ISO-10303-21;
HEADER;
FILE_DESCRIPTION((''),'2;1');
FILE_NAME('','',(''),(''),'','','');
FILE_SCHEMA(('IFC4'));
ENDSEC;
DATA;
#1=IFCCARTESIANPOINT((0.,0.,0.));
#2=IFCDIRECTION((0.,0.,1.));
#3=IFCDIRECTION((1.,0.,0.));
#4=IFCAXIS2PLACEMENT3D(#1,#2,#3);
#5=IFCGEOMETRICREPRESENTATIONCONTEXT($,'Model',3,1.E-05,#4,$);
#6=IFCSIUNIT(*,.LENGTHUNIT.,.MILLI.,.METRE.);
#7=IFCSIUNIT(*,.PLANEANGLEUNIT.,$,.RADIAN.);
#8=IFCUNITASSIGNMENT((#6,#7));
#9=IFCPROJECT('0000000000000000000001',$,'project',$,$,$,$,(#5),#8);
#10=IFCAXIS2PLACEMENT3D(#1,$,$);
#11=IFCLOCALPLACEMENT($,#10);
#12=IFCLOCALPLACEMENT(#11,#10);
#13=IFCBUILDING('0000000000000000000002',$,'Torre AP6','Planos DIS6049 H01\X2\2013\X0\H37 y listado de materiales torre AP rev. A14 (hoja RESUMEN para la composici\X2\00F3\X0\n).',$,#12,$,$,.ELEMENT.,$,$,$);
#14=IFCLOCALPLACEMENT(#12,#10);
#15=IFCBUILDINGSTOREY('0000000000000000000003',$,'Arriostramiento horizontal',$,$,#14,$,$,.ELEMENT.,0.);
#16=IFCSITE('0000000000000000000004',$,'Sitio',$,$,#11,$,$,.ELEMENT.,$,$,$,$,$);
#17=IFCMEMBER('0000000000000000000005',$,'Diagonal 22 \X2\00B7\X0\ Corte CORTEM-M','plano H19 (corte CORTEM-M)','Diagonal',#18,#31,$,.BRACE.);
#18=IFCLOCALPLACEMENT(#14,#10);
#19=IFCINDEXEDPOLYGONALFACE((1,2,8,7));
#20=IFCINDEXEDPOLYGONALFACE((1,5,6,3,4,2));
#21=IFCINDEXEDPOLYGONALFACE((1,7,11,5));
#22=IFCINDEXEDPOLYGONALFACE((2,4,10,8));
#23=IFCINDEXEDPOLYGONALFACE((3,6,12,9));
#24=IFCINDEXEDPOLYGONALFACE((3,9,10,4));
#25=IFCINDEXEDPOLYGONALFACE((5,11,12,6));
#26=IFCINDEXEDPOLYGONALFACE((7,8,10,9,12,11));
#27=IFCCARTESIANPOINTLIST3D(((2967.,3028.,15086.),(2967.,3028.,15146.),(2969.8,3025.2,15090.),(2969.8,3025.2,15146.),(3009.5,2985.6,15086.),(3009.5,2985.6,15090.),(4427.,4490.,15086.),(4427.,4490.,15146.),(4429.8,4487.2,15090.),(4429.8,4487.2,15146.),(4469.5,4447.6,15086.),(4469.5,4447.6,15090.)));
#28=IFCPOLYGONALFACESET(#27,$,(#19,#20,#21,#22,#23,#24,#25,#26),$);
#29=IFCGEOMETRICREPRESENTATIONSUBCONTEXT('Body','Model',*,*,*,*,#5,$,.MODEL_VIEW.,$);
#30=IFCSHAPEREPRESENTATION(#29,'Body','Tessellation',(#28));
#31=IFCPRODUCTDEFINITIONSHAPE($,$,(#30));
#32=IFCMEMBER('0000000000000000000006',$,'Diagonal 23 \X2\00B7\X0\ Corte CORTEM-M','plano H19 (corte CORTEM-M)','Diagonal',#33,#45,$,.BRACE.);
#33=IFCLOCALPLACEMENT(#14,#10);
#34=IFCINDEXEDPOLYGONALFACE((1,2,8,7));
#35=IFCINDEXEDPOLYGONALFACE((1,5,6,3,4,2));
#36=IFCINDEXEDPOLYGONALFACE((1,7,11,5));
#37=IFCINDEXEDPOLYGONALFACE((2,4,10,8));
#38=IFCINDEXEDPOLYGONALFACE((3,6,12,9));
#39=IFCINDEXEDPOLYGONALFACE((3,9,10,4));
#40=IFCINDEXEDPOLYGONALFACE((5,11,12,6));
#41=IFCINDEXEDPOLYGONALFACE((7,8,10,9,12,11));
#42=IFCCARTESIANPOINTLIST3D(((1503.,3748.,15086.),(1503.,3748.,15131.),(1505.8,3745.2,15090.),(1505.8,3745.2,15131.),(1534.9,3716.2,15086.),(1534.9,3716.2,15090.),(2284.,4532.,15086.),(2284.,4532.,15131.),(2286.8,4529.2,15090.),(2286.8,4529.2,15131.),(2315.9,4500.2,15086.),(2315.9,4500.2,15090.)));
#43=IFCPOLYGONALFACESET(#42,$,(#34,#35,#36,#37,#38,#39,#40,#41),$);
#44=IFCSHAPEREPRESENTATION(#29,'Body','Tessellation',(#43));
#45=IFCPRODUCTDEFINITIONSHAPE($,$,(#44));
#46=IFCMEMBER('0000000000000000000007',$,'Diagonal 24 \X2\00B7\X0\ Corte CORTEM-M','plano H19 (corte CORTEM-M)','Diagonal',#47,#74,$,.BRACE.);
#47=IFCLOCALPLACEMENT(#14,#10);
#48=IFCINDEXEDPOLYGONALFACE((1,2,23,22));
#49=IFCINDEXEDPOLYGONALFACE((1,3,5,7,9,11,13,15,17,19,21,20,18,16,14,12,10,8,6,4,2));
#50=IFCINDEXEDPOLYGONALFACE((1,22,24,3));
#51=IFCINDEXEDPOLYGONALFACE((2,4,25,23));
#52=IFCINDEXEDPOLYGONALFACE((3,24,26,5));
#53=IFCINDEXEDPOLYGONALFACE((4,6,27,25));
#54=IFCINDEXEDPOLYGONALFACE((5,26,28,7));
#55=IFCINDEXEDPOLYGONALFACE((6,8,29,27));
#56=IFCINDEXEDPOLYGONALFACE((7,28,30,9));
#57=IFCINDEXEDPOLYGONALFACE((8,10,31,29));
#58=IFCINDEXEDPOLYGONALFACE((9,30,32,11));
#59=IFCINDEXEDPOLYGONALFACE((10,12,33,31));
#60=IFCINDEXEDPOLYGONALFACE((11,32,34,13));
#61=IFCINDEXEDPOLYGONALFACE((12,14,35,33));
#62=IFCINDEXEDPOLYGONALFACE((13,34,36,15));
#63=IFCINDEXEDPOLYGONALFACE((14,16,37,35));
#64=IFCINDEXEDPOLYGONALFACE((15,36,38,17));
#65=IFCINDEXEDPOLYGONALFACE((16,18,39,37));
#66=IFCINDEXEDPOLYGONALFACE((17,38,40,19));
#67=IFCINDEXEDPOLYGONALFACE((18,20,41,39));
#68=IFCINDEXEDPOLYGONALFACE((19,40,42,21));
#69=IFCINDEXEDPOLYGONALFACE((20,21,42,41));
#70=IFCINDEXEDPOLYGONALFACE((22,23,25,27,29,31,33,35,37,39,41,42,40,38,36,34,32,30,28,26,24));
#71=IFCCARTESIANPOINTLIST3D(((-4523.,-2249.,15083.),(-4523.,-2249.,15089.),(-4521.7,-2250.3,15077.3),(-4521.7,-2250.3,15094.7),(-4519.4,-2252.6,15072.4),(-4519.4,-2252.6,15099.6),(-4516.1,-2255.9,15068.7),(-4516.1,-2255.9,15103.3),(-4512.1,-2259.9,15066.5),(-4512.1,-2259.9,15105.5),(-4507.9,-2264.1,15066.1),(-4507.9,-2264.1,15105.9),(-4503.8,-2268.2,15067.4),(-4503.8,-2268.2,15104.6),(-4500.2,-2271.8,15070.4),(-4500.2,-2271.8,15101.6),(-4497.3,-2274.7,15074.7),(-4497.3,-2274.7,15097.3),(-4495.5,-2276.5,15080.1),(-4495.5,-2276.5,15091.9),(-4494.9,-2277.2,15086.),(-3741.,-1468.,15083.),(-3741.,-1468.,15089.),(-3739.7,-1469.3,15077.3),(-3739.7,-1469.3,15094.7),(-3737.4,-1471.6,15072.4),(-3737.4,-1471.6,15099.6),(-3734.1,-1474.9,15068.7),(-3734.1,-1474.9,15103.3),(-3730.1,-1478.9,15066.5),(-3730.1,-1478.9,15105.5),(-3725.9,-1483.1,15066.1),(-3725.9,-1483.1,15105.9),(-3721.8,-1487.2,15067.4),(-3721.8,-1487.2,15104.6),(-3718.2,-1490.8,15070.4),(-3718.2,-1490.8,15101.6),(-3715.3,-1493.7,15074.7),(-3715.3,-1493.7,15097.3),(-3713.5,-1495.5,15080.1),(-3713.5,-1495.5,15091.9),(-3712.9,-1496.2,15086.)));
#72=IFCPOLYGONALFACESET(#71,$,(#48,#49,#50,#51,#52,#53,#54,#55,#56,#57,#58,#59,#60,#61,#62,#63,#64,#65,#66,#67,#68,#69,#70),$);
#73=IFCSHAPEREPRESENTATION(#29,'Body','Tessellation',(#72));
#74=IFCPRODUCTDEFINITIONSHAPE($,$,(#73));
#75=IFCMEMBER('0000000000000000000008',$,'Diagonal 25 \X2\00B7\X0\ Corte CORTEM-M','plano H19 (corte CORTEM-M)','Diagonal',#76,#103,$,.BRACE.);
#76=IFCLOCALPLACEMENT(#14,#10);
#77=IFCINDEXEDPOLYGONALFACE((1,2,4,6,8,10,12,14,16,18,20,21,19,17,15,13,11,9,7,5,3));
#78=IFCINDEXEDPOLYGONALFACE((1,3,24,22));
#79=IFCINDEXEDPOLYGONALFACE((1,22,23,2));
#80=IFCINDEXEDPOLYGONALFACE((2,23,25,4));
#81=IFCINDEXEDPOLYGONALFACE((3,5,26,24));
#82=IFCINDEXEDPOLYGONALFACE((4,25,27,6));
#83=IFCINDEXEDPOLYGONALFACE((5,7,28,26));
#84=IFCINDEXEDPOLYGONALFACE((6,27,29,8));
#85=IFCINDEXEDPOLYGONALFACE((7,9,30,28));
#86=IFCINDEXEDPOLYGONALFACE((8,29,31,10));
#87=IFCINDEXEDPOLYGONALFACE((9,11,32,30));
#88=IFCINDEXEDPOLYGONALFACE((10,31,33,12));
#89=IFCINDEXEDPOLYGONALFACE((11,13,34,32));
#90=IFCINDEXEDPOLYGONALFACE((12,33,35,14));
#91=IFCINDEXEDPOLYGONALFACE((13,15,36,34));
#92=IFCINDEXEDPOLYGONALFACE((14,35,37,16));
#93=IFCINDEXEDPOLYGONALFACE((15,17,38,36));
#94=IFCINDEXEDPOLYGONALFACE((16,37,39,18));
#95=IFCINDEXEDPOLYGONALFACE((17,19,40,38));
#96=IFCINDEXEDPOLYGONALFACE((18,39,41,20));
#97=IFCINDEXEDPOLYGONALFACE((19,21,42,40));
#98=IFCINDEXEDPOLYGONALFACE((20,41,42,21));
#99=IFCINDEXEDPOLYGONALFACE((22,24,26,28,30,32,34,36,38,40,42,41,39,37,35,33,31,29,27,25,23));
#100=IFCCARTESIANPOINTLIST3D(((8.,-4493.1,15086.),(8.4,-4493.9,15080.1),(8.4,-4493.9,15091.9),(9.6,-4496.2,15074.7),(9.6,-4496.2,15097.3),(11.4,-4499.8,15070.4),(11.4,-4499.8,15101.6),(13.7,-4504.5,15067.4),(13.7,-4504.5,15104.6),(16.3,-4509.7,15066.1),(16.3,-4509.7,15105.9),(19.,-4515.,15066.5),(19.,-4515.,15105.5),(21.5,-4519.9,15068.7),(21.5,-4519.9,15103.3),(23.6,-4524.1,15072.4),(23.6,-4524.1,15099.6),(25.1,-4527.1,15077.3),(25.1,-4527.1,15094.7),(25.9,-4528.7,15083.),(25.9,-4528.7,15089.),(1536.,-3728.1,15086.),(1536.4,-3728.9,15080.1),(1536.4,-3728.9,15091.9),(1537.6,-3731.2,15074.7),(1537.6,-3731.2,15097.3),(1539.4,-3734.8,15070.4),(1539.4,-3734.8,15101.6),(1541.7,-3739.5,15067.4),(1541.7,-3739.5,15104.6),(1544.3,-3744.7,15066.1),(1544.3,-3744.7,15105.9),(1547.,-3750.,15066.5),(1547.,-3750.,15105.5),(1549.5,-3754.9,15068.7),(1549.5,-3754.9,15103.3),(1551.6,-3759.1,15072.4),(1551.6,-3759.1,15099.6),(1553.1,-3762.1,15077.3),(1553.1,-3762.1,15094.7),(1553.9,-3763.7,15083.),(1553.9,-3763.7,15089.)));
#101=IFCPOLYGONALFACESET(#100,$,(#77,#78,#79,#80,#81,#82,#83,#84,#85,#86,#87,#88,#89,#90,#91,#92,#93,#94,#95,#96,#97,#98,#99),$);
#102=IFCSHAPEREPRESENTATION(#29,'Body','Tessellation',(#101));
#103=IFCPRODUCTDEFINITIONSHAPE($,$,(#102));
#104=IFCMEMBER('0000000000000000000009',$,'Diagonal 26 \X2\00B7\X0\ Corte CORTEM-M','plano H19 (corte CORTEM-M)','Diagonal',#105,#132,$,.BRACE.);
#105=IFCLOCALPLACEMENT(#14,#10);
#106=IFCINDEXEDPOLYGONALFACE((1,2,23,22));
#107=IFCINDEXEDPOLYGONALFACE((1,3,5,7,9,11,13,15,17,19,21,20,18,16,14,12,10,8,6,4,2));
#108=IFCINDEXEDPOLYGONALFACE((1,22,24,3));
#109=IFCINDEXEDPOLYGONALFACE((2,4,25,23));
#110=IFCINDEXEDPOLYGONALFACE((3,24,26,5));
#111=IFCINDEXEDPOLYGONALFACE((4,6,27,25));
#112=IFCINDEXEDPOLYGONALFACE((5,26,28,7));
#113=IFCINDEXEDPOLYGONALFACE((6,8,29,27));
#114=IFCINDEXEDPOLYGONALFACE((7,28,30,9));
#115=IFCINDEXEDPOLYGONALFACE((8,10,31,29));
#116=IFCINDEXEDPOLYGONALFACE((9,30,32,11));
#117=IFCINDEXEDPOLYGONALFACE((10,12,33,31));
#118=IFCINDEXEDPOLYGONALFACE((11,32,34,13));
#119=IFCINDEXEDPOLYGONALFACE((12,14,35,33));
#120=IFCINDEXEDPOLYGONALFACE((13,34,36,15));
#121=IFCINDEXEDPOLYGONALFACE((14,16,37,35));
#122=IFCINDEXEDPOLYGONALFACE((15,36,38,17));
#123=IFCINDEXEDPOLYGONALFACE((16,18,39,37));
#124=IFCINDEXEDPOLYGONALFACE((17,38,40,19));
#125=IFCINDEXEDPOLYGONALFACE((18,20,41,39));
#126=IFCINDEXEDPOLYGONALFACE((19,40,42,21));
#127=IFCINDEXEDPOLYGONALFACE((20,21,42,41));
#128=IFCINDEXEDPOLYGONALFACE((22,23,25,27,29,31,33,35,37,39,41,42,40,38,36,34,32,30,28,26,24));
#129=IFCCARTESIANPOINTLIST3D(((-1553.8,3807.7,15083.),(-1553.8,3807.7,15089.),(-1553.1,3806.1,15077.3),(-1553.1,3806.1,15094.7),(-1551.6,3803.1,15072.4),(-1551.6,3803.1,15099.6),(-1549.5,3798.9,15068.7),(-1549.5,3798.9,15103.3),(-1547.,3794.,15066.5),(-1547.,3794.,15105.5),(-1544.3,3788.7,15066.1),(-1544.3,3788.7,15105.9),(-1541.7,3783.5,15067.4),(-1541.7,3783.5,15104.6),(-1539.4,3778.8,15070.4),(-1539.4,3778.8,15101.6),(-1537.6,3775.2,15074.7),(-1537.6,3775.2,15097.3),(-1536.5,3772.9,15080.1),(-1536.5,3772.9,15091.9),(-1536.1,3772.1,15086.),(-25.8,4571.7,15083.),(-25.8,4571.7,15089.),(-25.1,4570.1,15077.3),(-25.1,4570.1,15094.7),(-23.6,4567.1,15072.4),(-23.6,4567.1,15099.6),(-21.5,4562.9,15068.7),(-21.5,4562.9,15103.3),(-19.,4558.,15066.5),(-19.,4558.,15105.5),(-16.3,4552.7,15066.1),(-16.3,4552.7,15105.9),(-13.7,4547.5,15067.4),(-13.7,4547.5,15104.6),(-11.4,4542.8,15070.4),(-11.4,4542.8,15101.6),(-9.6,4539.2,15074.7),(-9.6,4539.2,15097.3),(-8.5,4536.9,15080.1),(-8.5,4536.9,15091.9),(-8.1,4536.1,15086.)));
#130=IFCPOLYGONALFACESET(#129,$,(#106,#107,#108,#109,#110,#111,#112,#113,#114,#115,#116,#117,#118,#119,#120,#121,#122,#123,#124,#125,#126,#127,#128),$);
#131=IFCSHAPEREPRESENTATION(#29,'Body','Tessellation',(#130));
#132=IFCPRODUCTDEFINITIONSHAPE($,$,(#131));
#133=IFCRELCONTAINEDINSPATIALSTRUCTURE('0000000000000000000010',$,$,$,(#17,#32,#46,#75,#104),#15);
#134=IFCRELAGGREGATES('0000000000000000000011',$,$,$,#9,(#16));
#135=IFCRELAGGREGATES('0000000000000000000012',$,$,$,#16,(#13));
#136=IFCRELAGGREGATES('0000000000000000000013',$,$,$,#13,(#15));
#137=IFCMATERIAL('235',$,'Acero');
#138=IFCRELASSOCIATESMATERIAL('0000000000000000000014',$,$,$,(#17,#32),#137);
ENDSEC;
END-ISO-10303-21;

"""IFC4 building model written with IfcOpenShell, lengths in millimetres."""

from ifc_helpers import new_model, si_unit, frame, frame_2d, origin, origin_with_axes, place, context, subcontext, project, spatial, circle, l_section, extrude, material, element, save


model = new_model("IFC4")

# Units and contexts
model_context = context("Model", 3, precision=1e-05, world=origin_with_axes())
body_context = subcontext(model_context, "Body", "Model", "MODEL_VIEW")
ifc_project = project(units=[si_unit("LENGTHUNIT", "METRE", prefix="MILLI"), si_unit("PLANEANGLEUNIT", "RADIAN")], contexts=[model_context])

# Site, building, storey
site_placement = place(None, origin())
site = spatial("IfcSite", under=ifc_project, at=site_placement, Name="Sitio", CompositionType="ELEMENT")
building_placement = place(site_placement, origin())
building = spatial("IfcBuilding", under=site, at=building_placement, Name="Torre AP6", Description="Planos DIS6049 H01–H37 y listado de materiales torre AP rev. A14 (hoja RESUMEN para la composición).", CompositionType="ELEMENT")
storey_placement = place(building_placement, origin())
storey = spatial("IfcBuildingStorey", under=building, at=storey_placement, Name="Arriostramiento horizontal", CompositionType="ELEMENT", Elevation=0.0)

# Members
ifc_material = material(Name="235", Category="Acero")
for number, where, z_axis, x_axis, name in (
    (1, (4427.0, 4490.0, 15086.0), (-0.706623, -0.707591, 0.0), (0.707591, -0.706623, 0.0), "Diagonal 22 · Corte CORTEM-M"),
):
    element("IfcMember", number, at=place(storey_placement, frame(where, z_axis=z_axis, x_axis=x_axis)), inside=storey, material=ifc_material, Name=name, Description="plano H19 (corte CORTEM-M)", ObjectType="Diagonal", PredefinedType="BRACE", context=body_context, shape_type="SweptSolid", body=[
        extrude(l_section(Depth=60.0, Width=60.0, Thickness=4.0, at=frame_2d((30.0, 30.0))), None, (0.0, 0.0, 1.0), 2066.2),
    ])
member_1_placement = place(storey_placement, frame((2284.0, 4532.0, 15086.0), z_axis=(-0.70575, -0.708461, 0.0), x_axis=(0.708461, -0.70575, 0.0)))
element("IfcMember", 2, at=member_1_placement, inside=storey, material=ifc_material, Name="Diagonal 23 · Corte CORTEM-M", Description="plano H19 (corte CORTEM-M)", ObjectType="Diagonal", PredefinedType="BRACE", context=body_context, shape_type="SweptSolid", body=[
    extrude(l_section(Depth=45.0, Width=45.0, Thickness=4.0, at=frame_2d((22.5, 22.5))), None, (0.0, 0.0, 1.0), 1106.6),
])
member_2_placement = place(storey_placement, frame((-3727.0, -1482.0, 15086.0), z_axis=(-0.707559, -0.706654, 0.0), x_axis=(0.706654, -0.707559, 0.0)))
element("IfcMember", 3, at=member_2_placement, inside=storey, Name="Diagonal 24 · Corte CORTEM-M", Description="plano H19 (corte CORTEM-M)", ObjectType="Diagonal", PredefinedType="BRACE", context=body_context, shape_type="SweptSolid", body=[
    extrude(circle(Radius=20.0), None, (0.0, 0.0, 1.0), 1105.2),
])
member_3_placement = place(storey_placement, frame((1545.0, -3746.0, 15086.0), z_axis=(-0.894193, -0.447682, 0.0), x_axis=(-0.447682, 0.894193, 0.0)))
element("IfcMember", 4, at=member_3_placement, inside=storey, Name="Diagonal 25 · Corte CORTEM-M", Description="plano H19 (corte CORTEM-M)", ObjectType="Diagonal", PredefinedType="BRACE", context=body_context, shape_type="SweptSolid", body=[
    extrude(circle(Radius=20.0), None, (0.0, 0.0, 1.0), 1708.8),
])
member_4_placement = place(storey_placement, frame((-17.0, 4554.0, 15086.0), z_axis=(-0.894427, -0.447214, 0.0), x_axis=(0.447214, -0.894427, 0.0)))
element("IfcMember", 5, at=member_4_placement, inside=storey, Name="Diagonal 26 · Corte CORTEM-M", Description="plano H19 (corte CORTEM-M)", ObjectType="Diagonal", PredefinedType="BRACE", context=body_context, shape_type="SweptSolid", body=[
    extrude(circle(Radius=20.0), None, (0.0, 0.0, 1.0), 1708.4),
])

save(model, "model.ifc")
